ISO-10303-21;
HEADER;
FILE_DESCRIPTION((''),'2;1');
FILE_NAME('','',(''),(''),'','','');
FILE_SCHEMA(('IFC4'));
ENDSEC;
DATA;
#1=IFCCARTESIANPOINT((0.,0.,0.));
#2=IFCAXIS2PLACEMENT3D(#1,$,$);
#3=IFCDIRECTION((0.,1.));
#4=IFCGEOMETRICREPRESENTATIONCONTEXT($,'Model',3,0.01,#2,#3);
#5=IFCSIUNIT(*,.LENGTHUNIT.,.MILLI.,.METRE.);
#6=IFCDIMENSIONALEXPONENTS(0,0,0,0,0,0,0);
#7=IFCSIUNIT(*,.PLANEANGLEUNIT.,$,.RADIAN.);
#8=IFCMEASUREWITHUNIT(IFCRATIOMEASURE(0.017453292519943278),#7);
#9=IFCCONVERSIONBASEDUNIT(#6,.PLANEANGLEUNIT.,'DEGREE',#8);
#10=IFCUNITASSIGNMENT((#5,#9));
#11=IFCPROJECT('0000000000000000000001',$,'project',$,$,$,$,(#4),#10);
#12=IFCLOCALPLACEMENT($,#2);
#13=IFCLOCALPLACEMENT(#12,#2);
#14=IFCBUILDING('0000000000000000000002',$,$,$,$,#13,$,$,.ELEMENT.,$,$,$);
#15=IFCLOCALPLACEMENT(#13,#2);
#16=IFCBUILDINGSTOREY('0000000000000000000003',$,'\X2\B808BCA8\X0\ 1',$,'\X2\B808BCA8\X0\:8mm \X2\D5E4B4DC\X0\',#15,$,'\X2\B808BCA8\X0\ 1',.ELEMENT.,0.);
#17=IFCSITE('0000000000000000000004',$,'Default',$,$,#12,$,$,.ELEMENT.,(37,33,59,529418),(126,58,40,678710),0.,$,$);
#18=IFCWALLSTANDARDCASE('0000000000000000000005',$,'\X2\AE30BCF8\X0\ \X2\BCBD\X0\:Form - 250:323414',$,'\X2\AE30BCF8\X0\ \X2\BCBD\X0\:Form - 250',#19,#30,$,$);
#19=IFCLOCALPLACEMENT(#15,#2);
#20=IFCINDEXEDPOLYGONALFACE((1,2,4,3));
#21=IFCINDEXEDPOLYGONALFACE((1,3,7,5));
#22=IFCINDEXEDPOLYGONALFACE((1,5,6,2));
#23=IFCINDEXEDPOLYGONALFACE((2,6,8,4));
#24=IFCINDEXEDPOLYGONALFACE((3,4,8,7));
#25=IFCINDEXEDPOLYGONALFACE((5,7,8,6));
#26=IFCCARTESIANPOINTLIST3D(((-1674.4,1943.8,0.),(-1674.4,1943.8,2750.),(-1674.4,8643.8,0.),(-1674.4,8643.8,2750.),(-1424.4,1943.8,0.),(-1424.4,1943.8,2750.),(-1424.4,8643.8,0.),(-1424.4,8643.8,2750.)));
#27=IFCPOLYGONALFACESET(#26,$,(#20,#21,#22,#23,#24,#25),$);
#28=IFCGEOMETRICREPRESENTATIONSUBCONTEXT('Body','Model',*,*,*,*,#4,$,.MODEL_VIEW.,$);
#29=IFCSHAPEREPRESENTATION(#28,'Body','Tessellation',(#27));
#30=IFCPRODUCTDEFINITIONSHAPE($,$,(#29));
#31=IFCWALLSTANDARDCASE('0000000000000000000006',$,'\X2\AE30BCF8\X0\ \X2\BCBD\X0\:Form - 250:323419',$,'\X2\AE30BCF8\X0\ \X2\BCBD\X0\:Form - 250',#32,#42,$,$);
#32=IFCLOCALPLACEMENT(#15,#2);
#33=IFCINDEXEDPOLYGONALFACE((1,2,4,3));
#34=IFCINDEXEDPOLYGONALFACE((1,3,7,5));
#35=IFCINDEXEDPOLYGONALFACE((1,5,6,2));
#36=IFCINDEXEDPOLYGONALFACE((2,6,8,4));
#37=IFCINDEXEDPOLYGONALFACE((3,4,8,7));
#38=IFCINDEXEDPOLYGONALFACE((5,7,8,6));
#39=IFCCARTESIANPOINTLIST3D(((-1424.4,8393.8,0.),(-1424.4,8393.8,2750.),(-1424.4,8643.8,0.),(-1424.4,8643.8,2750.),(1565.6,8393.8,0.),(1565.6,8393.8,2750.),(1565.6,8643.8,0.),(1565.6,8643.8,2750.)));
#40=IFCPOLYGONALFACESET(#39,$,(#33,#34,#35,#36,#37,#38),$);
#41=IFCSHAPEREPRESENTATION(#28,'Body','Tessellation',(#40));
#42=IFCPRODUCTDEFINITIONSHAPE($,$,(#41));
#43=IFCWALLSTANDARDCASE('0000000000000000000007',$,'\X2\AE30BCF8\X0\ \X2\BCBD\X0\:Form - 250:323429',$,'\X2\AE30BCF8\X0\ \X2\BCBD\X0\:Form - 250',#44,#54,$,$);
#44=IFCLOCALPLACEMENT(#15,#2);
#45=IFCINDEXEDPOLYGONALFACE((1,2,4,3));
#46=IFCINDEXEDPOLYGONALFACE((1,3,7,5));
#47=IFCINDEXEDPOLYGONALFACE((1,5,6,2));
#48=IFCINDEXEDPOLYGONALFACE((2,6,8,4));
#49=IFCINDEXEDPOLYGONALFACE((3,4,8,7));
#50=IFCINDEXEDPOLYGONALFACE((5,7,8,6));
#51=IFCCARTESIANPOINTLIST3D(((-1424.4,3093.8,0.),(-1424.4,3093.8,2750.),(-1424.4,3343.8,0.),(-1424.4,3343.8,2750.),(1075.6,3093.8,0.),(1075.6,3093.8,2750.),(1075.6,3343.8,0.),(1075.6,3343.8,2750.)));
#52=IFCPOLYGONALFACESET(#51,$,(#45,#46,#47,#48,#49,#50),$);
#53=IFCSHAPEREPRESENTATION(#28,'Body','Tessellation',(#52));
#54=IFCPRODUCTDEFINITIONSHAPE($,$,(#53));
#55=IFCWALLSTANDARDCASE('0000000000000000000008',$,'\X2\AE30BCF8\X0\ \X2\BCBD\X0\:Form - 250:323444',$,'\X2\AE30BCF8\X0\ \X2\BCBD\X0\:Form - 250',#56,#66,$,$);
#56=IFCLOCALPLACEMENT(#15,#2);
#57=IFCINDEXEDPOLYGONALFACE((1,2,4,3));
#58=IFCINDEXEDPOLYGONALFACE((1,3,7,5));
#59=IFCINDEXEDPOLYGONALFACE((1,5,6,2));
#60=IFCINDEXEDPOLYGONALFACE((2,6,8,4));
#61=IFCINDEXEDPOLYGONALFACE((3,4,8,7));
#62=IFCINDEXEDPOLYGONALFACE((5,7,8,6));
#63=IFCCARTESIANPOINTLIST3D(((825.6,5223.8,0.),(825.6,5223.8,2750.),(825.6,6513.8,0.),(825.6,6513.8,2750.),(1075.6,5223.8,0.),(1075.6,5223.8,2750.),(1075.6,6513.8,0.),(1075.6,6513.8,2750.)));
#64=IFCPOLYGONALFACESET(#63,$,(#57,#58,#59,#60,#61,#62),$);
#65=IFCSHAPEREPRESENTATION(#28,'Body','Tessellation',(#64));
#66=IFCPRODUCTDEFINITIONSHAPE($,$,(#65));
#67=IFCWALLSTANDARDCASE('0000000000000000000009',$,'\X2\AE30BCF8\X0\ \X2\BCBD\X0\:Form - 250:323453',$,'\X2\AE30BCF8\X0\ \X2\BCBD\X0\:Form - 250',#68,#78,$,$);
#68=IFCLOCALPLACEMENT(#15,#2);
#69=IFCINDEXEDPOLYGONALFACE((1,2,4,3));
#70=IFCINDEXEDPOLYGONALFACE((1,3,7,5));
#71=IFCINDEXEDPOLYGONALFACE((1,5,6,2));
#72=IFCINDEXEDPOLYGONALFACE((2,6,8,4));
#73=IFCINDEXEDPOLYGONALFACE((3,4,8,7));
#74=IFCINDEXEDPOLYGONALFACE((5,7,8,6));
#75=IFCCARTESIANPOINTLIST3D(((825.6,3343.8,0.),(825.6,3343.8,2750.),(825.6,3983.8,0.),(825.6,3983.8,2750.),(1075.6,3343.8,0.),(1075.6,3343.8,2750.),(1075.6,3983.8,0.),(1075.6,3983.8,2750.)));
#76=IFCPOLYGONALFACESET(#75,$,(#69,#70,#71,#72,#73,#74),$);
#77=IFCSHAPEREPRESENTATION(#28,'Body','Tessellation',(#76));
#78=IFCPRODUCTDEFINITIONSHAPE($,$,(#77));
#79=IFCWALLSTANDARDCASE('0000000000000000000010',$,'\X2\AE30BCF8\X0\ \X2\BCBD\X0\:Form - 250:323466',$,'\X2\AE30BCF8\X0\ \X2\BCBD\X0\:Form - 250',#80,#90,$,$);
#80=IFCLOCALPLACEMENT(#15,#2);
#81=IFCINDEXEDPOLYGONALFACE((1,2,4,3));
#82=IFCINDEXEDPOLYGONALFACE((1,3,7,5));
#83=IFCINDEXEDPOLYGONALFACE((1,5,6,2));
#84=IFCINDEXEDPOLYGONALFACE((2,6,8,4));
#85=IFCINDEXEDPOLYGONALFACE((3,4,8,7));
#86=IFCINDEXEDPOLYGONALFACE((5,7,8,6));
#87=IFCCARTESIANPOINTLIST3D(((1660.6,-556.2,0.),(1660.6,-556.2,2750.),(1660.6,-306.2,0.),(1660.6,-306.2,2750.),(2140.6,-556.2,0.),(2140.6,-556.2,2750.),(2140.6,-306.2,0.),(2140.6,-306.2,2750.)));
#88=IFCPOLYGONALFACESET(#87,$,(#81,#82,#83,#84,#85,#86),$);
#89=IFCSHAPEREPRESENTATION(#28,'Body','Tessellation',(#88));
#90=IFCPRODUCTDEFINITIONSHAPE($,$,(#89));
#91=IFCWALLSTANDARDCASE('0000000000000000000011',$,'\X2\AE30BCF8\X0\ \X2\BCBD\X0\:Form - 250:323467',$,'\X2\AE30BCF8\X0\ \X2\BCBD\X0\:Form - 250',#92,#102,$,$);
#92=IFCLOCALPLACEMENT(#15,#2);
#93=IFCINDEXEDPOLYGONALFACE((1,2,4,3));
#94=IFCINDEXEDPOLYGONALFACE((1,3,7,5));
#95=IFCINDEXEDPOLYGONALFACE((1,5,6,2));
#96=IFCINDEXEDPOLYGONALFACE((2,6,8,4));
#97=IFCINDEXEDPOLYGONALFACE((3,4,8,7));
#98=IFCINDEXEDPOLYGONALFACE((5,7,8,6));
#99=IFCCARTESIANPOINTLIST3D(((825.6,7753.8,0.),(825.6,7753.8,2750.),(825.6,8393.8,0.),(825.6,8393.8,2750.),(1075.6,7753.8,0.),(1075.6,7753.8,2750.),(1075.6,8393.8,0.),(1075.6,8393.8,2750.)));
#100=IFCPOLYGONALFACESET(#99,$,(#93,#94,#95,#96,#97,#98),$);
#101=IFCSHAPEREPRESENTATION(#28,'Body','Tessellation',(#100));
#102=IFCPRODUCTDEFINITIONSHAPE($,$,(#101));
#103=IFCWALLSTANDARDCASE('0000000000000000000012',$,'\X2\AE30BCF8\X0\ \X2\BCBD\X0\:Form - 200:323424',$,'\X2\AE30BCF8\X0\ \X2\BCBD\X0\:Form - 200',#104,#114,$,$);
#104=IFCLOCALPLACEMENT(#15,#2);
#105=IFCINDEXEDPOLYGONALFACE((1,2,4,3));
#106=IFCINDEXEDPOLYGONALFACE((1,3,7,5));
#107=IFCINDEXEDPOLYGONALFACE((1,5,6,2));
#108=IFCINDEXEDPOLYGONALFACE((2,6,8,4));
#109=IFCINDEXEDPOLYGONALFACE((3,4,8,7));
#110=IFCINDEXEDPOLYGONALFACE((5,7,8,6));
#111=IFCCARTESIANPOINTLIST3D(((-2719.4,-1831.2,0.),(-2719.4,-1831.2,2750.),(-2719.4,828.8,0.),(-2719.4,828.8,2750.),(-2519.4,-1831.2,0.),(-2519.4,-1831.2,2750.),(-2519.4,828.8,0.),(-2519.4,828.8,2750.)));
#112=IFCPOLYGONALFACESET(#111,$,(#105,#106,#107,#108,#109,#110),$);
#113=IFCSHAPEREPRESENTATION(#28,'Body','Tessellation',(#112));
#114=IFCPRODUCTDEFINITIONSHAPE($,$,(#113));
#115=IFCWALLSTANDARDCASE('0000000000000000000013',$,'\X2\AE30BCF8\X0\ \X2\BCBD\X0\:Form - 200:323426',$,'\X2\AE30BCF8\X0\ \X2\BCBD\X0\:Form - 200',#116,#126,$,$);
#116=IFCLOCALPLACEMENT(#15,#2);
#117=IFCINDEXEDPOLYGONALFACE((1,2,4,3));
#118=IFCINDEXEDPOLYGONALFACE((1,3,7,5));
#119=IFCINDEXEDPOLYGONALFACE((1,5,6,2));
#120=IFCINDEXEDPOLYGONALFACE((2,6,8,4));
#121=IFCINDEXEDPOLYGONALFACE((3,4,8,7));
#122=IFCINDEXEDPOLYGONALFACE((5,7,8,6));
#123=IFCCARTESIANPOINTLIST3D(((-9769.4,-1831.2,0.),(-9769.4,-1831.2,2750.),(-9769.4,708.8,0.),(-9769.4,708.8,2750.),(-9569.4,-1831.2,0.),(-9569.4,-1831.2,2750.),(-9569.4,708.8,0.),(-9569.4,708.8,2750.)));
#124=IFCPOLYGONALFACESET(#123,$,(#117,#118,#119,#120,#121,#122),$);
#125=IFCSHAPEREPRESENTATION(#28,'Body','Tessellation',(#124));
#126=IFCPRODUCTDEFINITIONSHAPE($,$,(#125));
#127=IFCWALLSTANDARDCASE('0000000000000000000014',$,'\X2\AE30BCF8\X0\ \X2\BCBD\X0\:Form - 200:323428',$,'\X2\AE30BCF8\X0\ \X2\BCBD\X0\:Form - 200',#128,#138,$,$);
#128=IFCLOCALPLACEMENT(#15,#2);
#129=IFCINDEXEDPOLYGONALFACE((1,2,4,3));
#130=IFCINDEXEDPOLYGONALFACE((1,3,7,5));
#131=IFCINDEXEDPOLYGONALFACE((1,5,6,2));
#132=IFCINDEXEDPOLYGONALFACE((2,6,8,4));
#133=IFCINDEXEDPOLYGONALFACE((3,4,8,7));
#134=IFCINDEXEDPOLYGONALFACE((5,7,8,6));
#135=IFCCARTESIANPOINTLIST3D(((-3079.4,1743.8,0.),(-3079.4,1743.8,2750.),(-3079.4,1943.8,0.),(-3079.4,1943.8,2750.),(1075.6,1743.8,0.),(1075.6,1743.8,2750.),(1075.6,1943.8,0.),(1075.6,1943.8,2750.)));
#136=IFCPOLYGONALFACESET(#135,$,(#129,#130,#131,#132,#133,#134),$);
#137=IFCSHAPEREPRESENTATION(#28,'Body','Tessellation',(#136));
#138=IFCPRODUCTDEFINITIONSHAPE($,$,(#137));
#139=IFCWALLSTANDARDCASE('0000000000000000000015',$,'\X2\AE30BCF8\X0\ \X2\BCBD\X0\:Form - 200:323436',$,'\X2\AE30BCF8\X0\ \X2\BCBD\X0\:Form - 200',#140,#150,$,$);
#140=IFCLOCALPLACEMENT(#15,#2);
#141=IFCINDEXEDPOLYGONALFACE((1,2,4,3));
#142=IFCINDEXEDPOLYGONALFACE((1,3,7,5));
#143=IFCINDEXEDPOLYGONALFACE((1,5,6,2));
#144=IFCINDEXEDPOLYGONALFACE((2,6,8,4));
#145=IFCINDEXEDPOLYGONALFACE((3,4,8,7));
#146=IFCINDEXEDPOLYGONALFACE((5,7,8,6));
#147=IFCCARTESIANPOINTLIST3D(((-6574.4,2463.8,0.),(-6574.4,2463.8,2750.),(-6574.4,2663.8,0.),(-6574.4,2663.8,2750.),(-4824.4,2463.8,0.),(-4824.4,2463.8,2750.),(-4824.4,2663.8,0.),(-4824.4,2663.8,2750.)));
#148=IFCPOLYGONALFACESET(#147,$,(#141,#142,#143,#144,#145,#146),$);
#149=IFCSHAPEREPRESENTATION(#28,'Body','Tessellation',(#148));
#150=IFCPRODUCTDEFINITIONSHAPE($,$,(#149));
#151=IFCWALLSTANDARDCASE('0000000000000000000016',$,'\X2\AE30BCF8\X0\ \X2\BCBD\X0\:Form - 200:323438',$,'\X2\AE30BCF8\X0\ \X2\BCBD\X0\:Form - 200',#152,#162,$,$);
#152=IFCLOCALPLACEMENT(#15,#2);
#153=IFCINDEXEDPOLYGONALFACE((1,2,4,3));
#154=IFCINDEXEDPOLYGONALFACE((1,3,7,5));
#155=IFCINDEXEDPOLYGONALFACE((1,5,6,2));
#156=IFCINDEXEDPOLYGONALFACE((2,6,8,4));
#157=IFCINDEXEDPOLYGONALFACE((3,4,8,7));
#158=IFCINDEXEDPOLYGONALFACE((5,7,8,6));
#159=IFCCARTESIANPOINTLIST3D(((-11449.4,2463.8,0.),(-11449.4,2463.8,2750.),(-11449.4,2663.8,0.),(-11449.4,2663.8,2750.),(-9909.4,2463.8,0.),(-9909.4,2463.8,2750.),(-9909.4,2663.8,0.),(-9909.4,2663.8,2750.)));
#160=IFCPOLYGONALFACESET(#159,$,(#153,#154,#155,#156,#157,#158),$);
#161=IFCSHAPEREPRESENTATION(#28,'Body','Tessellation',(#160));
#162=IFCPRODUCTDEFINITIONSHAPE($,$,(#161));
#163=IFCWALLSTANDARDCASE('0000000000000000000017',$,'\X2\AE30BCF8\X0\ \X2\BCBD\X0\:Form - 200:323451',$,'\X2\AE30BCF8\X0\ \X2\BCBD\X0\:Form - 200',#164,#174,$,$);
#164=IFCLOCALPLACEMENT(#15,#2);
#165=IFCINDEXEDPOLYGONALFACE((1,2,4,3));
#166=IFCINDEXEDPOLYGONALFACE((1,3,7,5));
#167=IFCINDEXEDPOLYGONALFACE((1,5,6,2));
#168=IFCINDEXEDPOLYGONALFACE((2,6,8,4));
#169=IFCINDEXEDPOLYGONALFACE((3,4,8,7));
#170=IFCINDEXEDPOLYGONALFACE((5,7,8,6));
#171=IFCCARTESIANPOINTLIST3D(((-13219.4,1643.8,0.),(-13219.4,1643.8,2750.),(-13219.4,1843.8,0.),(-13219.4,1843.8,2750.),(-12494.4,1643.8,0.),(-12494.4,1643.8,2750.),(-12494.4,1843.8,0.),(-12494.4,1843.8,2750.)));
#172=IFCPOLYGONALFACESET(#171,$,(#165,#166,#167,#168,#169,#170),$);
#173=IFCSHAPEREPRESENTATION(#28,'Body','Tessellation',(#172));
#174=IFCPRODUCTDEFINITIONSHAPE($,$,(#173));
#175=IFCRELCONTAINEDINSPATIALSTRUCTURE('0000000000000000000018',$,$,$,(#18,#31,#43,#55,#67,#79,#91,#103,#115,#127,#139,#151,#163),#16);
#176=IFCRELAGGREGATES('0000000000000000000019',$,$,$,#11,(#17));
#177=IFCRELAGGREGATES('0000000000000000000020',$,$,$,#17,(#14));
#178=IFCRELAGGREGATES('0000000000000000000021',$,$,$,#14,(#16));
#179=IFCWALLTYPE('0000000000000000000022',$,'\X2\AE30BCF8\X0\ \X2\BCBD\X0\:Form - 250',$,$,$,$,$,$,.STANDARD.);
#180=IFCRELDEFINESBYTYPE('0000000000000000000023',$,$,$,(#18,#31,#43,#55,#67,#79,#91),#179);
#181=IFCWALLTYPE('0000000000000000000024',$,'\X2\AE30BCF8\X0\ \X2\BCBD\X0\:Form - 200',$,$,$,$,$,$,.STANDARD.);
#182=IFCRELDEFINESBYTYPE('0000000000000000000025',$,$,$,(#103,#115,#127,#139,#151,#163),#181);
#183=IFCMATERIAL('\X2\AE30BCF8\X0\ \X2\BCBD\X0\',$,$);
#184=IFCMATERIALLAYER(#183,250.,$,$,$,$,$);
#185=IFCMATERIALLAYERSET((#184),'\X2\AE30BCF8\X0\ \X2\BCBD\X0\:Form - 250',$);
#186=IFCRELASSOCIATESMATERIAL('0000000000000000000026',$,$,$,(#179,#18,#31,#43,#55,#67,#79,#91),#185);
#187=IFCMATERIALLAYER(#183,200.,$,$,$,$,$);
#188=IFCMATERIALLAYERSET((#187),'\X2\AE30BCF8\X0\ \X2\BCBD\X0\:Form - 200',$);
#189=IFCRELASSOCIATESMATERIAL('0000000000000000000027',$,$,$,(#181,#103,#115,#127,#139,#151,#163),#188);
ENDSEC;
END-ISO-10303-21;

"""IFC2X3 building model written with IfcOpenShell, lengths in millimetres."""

from ifc_helpers import new_model, entity, si_unit, converted_unit, direction, frame, frame_2d, origin, place, context, subcontext, project, spatial, rectangle, extrude, material, layer, layer_set, layer_usage, type_object, element, save


model = new_model("IFC2X3")

# Units and contexts
model_context = context("Model", 3, precision=0.01, world=origin(), true_north=direction((0.0, 1.0)))
body_context = subcontext(model_context, "Body", "Model", "MODEL_VIEW")
ifc_project = project(units=[si_unit("LENGTHUNIT", "METRE", prefix="MILLI"), converted_unit("PLANEANGLEUNIT", "DEGREE", entity("IfcRatioMeasure", 0.017453292519943278), si_unit("PLANEANGLEUNIT", "RADIAN"), dimensions=[0, 0, 0, 0, 0, 0, 0])], contexts=[model_context])

# Site, building, storey
site_placement = place(None, origin())
site = spatial("IfcSite", under=ifc_project, at=site_placement, Name="Default", CompositionType="ELEMENT", RefLatitude=(37, 33, 59, 529418), RefLongitude=(126, 58, 40, 678710), RefElevation=0.0)
building_placement = place(site_placement, origin())
building = spatial("IfcBuilding", under=site, at=building_placement, CompositionType="ELEMENT")
storey_placement = place(building_placement, origin())
storey = spatial("IfcBuildingStorey", under=building, at=storey_placement, Name="레벨 1", ObjectType="레벨:8mm 헤드", LongName="레벨 1", CompositionType="ELEMENT", Elevation=0.0)

# Walls
ifc_material_1 = material(Name="기본 벽")
ifc_layer_1 = layer(ifc_material_1, 250.0)
ifc_layer_set_1 = layer_set([ifc_layer_1], Name="기본 벽:Form - 250")
ifc_layer_usage_1 = layer_usage(ifc_layer_set_1, "AXIS2", "POSITIVE", -125.0)
wall_type_1 = type_object("IfcWallType", Name="기본 벽:Form - 250", PredefinedType="STANDARD", material=ifc_layer_set_1)
wall_1_placement = place(storey_placement, frame((-1549.4, 1943.8, 0.0), z_axis=(0.0, 0.0, 1.0), x_axis=(0.0, 1.0, 0.0)))
element("IfcWallStandardCase", 1, at=wall_1_placement, inside=storey, type_object=wall_type_1, material=ifc_layer_usage_1, Name="기본 벽:Form - 250:323414", ObjectType="기본 벽:Form - 250", context=body_context, shape_type="SweptSolid", body=[
    extrude(rectangle(XDim=6700.0, YDim=250.0, at=frame_2d((3350.0, 0.0), x_axis=(-1.0, 0.0))), origin(), (0.0, 0.0, 1.0), 2750.0),
])
ifc_layer_usage_2 = layer_usage(ifc_layer_set_1, "AXIS2", "POSITIVE", -125.0)
wall_2_placement = place(storey_placement, frame((-1424.4, 8518.8, 0.0)))
element("IfcWallStandardCase", 2, at=wall_2_placement, inside=storey, type_object=wall_type_1, material=ifc_layer_usage_2, Name="기본 벽:Form - 250:323419", ObjectType="기본 벽:Form - 250", context=body_context, shape_type="SweptSolid", body=[
    extrude(rectangle(XDim=2990.0, YDim=250.0, at=frame_2d((1495.0, 0.0), x_axis=(-1.0, 0.0))), origin(), (0.0, 0.0, 1.0), 2750.0),
])
ifc_layer_usage_3 = layer_usage(ifc_layer_set_1, "AXIS2", "POSITIVE", -125.0)
wall_3_placement = place(storey_placement, frame((-1424.4, 3218.8, 0.0)))
element("IfcWallStandardCase", 3, at=wall_3_placement, inside=storey, type_object=wall_type_1, material=ifc_layer_usage_3, Name="기본 벽:Form - 250:323429", ObjectType="기본 벽:Form - 250", context=body_context, shape_type="SweptSolid", body=[
    extrude(rectangle(XDim=2500.0, YDim=250.0, at=frame_2d((1250.0, 0.0), x_axis=(-1.0, 0.0))), origin(), (0.0, 0.0, 1.0), 2750.0),
])
ifc_layer_usage_4 = layer_usage(ifc_layer_set_1, "AXIS2", "POSITIVE", -125.0)
wall_4_placement = place(storey_placement, frame((950.6, 5223.8, 0.0), z_axis=(0.0, 0.0, 1.0), x_axis=(0.0, 1.0, 0.0)))
element("IfcWallStandardCase", 4, at=wall_4_placement, inside=storey, type_object=wall_type_1, material=ifc_layer_usage_4, Name="기본 벽:Form - 250:323444", ObjectType="기본 벽:Form - 250", context=body_context, shape_type="SweptSolid", body=[
    extrude(rectangle(XDim=1290.0, YDim=250.0, at=frame_2d((645.0, 0.0), x_axis=(-1.0, 0.0))), origin(), (0.0, 0.0, 1.0), 2750.0),
])
ifc_layer_usage_5 = layer_usage(ifc_layer_set_1, "AXIS2", "POSITIVE", -125.0)
wall_5_placement = place(storey_placement, frame((950.6, 3983.8, 0.0), z_axis=(0.0, 0.0, 1.0), x_axis=(0.0, -1.0, 0.0)))
element("IfcWallStandardCase", 5, at=wall_5_placement, inside=storey, type_object=wall_type_1, material=ifc_layer_usage_5, Name="기본 벽:Form - 250:323453", ObjectType="기본 벽:Form - 250", context=body_context, shape_type="SweptSolid", body=[
    extrude(rectangle(XDim=640.0, YDim=250.0, at=frame_2d((320.0, 0.0), x_axis=(-1.0, 0.0))), origin(), (0.0, 0.0, 1.0), 2750.0),
])
ifc_layer_usage_6 = layer_usage(ifc_layer_set_1, "AXIS2", "POSITIVE", -125.0)
wall_6_placement = place(storey_placement, frame((2140.6, -431.2, 0.0), z_axis=(0.0, 0.0, 1.0), x_axis=(-1.0, 0.0, 0.0)))
element("IfcWallStandardCase", 6, at=wall_6_placement, inside=storey, type_object=wall_type_1, material=ifc_layer_usage_6, Name="기본 벽:Form - 250:323466", ObjectType="기본 벽:Form - 250", context=body_context, shape_type="SweptSolid", body=[
    extrude(rectangle(XDim=480.0, YDim=250.0, at=frame_2d((240.0, 0.0), x_axis=(-1.0, 0.0))), origin(), (0.0, 0.0, 1.0), 2750.0),
])
ifc_layer_usage_7 = layer_usage(ifc_layer_set_1, "AXIS2", "POSITIVE", -125.0)
wall_7_placement = place(storey_placement, frame((950.6, 8393.8, 0.0), z_axis=(0.0, 0.0, 1.0), x_axis=(0.0, -1.0, 0.0)))
element("IfcWallStandardCase", 7, at=wall_7_placement, inside=storey, type_object=wall_type_1, material=ifc_layer_usage_7, Name="기본 벽:Form - 250:323467", ObjectType="기본 벽:Form - 250", context=body_context, shape_type="SweptSolid", body=[
    extrude(rectangle(XDim=640.0, YDim=250.0, at=frame_2d((320.0, 0.0), x_axis=(-1.0, 0.0))), origin(), (0.0, 0.0, 1.0), 2750.0),
])
ifc_layer_2 = layer(ifc_material_1, 200.0)
ifc_layer_set_2 = layer_set([ifc_layer_2], Name="기본 벽:Form - 200")
ifc_layer_usage_8 = layer_usage(ifc_layer_set_2, "AXIS2", "POSITIVE", -100.0)
wall_type_2 = type_object("IfcWallType", Name="기본 벽:Form - 200", PredefinedType="STANDARD", material=ifc_layer_set_2)
wall_8_placement = place(storey_placement, frame((-2619.4, 828.8, 0.0), z_axis=(0.0, 0.0, 1.0), x_axis=(0.0, -1.0, 0.0)))
element("IfcWallStandardCase", 8, at=wall_8_placement, inside=storey, type_object=wall_type_2, material=ifc_layer_usage_8, Name="기본 벽:Form - 200:323424", ObjectType="기본 벽:Form - 200", context=body_context, shape_type="SweptSolid", body=[
    extrude(rectangle(XDim=2660.0, YDim=200.0, at=frame_2d((1330.0, 0.0), x_axis=(-1.0, 0.0))), origin(), (0.0, 0.0, 1.0), 2750.0),
])
ifc_layer_usage_9 = layer_usage(ifc_layer_set_2, "AXIS2", "POSITIVE", -100.0)
wall_9_placement = place(storey_placement, frame((-9669.4, 708.8, 0.0), z_axis=(0.0, 0.0, 1.0), x_axis=(0.0, -1.0, 0.0)))
element("IfcWallStandardCase", 9, at=wall_9_placement, inside=storey, type_object=wall_type_2, material=ifc_layer_usage_9, Name="기본 벽:Form - 200:323426", ObjectType="기본 벽:Form - 200", context=body_context, shape_type="SweptSolid", body=[
    extrude(rectangle(XDim=2540.0, YDim=200.0, at=frame_2d((1270.0, 0.0), x_axis=(-1.0, 0.0))), origin(), (0.0, 0.0, 1.0), 2750.0),
])
ifc_layer_usage_10 = layer_usage(ifc_layer_set_2, "AXIS2", "POSITIVE", -100.0)
wall_10_placement = place(storey_placement, frame((1075.6, 1843.8, 0.0), z_axis=(0.0, 0.0, 1.0), x_axis=(-1.0, 0.0, 0.0)))
element("IfcWallStandardCase", 10, at=wall_10_placement, inside=storey, type_object=wall_type_2, material=ifc_layer_usage_10, Name="기본 벽:Form - 200:323428", ObjectType="기본 벽:Form - 200", context=body_context, shape_type="SweptSolid", body=[
    extrude(rectangle(XDim=4155.0, YDim=200.0, at=frame_2d((2077.5, 0.0), x_axis=(-1.0, 0.0))), origin(), (0.0, 0.0, 1.0), 2750.0),
])
ifc_layer_usage_11 = layer_usage(ifc_layer_set_2, "AXIS2", "POSITIVE", -100.0)
wall_11_placement = place(storey_placement, frame((-6574.4, 2563.8, 0.0)))
element("IfcWallStandardCase", 11, at=wall_11_placement, inside=storey, type_object=wall_type_2, material=ifc_layer_usage_11, Name="기본 벽:Form - 200:323436", ObjectType="기본 벽:Form - 200", context=body_context, shape_type="SweptSolid", body=[
    extrude(rectangle(XDim=1750.0, YDim=200.0, at=frame_2d((875.0, 0.0), x_axis=(-1.0, 0.0))), origin(), (0.0, 0.0, 1.0), 2750.0),
])
ifc_layer_usage_12 = layer_usage(ifc_layer_set_2, "AXIS2", "POSITIVE", -100.0)
wall_12_placement = place(storey_placement, frame((-9909.4, 2563.8, 0.0), z_axis=(0.0, 0.0, 1.0), x_axis=(-1.0, 0.0, 0.0)))
element("IfcWallStandardCase", 12, at=wall_12_placement, inside=storey, type_object=wall_type_2, material=ifc_layer_usage_12, Name="기본 벽:Form - 200:323438", ObjectType="기본 벽:Form - 200", context=body_context, shape_type="SweptSolid", body=[
    extrude(rectangle(XDim=1540.0, YDim=200.0, at=frame_2d((770.0, 0.0), x_axis=(-1.0, 0.0))), origin(), (0.0, 0.0, 1.0), 2750.0),
])
ifc_layer_usage_13 = layer_usage(ifc_layer_set_2, "AXIS2", "POSITIVE", -100.0)
wall_13_placement = place(storey_placement, frame((-13219.4, 1743.8, 0.0)))
element("IfcWallStandardCase", 13, at=wall_13_placement, inside=storey, type_object=wall_type_2, material=ifc_layer_usage_13, Name="기본 벽:Form - 200:323451", ObjectType="기본 벽:Form - 200", context=body_context, shape_type="SweptSolid", body=[
    extrude(rectangle(XDim=725.0, YDim=200.0, at=frame_2d((362.5, 0.0), x_axis=(-1.0, 0.0))), origin(), (0.0, 0.0, 1.0), 2750.0),
])

save(model, "model.ifc")
